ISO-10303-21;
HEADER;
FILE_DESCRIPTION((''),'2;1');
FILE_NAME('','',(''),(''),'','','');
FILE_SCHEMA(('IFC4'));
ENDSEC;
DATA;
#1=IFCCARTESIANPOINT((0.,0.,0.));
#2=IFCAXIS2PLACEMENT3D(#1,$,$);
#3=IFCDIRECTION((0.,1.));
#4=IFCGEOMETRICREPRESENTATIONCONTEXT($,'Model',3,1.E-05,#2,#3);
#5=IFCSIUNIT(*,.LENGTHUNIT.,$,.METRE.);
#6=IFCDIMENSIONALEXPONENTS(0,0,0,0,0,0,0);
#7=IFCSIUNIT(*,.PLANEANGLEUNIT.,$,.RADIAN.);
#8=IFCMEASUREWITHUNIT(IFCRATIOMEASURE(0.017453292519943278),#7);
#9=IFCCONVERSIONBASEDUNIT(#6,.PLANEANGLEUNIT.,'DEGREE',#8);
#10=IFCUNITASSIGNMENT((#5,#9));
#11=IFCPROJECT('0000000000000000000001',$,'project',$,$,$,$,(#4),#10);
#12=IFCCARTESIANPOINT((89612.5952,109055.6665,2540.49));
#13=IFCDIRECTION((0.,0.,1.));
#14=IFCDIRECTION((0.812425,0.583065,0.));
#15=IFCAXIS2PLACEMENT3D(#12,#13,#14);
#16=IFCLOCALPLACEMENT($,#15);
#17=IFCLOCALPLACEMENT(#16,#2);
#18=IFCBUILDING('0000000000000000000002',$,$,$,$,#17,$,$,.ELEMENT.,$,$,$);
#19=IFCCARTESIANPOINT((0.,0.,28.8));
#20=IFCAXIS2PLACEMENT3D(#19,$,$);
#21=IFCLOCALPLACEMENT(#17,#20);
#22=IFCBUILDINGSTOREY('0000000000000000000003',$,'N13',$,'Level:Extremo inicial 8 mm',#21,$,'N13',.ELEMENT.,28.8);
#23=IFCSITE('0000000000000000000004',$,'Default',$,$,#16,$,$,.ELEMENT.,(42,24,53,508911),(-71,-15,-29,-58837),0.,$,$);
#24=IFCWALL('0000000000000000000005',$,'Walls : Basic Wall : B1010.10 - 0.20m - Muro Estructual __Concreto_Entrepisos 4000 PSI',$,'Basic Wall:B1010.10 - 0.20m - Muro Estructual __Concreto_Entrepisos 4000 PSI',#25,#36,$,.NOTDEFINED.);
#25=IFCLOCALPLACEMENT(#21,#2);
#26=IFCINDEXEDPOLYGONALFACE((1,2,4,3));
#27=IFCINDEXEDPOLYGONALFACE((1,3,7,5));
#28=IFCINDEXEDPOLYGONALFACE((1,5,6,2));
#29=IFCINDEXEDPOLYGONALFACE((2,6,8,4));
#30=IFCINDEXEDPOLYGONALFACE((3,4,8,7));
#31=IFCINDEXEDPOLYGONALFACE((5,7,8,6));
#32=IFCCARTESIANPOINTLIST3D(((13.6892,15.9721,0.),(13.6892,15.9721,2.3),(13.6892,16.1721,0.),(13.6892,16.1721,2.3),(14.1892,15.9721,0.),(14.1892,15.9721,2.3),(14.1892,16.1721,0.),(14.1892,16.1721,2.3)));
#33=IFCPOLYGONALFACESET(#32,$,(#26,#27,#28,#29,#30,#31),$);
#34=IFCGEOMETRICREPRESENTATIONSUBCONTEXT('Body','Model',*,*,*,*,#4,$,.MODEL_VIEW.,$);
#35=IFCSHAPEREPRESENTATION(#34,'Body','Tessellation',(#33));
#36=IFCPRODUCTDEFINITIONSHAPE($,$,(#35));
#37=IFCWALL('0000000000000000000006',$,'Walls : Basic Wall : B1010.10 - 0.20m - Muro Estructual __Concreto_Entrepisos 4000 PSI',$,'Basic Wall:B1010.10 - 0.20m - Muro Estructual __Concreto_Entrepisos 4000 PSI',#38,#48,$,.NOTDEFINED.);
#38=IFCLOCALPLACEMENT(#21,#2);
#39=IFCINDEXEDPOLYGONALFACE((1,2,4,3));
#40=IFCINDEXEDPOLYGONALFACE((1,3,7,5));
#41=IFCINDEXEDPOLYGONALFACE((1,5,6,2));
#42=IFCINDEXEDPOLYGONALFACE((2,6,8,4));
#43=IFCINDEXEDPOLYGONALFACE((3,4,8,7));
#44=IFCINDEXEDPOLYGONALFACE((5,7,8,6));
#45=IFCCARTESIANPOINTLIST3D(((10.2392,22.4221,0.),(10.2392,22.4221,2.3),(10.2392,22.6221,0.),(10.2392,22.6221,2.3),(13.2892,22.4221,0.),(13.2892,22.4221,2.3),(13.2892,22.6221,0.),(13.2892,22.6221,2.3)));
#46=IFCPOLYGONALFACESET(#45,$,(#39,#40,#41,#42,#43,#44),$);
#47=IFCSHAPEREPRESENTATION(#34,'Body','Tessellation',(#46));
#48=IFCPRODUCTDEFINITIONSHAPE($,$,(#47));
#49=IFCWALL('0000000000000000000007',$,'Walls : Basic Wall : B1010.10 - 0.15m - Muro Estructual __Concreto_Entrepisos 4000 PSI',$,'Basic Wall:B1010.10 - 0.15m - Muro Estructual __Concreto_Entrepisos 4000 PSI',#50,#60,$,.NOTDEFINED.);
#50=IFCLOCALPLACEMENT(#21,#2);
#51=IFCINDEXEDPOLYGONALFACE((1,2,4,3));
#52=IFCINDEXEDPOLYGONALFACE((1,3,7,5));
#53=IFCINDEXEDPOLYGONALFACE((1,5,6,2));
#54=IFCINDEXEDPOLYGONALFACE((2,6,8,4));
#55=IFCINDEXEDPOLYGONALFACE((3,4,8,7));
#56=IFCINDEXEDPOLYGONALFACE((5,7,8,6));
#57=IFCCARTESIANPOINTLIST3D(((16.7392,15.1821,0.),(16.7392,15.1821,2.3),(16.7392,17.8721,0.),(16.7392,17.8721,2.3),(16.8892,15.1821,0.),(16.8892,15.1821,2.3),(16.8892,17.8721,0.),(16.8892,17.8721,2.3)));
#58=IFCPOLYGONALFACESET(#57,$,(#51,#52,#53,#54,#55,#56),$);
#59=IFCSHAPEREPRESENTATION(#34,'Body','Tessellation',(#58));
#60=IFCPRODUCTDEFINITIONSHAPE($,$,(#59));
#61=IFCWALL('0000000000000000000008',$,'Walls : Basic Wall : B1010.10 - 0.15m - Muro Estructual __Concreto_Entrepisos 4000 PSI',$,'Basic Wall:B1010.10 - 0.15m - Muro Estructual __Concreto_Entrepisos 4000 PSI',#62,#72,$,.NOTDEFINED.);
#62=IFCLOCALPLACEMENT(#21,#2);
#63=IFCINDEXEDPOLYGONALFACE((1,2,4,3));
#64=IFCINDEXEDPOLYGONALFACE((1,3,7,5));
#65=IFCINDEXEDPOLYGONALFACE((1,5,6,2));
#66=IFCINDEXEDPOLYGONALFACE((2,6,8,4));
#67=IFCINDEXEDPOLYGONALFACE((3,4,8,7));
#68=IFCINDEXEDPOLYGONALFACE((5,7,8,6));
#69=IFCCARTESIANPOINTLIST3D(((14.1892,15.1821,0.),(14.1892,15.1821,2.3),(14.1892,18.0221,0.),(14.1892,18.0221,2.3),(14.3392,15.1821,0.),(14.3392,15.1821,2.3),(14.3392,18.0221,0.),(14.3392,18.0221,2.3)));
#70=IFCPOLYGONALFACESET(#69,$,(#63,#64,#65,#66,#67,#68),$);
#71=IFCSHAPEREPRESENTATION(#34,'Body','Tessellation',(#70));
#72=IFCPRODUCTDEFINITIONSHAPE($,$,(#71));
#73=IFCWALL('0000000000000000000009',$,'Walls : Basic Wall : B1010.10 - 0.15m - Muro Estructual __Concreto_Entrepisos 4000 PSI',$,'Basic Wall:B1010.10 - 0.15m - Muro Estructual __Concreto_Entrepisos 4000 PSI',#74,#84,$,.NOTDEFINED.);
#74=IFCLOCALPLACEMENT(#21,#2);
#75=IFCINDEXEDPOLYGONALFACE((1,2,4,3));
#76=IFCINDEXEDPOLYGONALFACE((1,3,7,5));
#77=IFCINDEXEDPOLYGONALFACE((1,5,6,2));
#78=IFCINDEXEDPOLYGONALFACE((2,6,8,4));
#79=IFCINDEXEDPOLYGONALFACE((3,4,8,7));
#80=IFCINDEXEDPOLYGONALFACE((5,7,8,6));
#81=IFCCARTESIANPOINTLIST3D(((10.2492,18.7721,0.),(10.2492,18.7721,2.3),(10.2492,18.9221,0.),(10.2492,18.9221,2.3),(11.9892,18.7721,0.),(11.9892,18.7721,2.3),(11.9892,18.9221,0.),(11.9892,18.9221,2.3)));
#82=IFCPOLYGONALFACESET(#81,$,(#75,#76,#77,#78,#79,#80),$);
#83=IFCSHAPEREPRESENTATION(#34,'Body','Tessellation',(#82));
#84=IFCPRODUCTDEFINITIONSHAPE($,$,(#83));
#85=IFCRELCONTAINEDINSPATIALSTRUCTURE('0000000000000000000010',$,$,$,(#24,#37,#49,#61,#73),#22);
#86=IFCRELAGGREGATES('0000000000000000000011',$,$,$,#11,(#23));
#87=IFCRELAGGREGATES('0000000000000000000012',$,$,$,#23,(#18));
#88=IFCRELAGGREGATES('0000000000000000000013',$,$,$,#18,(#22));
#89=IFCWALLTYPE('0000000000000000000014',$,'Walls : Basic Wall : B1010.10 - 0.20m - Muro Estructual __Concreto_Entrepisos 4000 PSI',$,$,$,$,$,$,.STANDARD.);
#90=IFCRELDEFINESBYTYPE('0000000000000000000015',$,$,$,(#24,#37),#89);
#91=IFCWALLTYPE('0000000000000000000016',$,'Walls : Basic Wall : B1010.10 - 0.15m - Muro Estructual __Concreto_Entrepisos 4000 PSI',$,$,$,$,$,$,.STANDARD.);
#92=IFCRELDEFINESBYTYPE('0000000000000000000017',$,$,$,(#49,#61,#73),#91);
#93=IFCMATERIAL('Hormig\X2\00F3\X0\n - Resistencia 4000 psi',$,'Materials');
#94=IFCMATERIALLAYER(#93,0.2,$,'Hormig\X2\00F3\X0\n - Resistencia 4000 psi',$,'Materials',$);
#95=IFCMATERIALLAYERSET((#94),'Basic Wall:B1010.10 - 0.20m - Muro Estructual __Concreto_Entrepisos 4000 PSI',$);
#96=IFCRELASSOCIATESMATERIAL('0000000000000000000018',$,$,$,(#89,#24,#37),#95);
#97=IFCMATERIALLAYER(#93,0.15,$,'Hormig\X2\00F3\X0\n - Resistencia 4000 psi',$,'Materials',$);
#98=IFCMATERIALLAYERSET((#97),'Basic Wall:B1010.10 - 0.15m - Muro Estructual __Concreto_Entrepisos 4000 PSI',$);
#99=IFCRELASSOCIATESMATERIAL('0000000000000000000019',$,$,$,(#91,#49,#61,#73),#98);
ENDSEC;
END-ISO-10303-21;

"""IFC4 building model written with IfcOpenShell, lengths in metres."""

from ifc_helpers import new_model, entity, si_unit, converted_unit, direction, frame, frame_2d, origin, place, context, subcontext, project, spatial, rectangle, extrude, material, layer, layer_set, layer_usage, type_object, element, save


model = new_model("IFC4")

# Units and contexts
model_context = context("Model", 3, precision=1e-05, world=origin(), true_north=direction((0.0, 1.0)))
body_context = subcontext(model_context, "Body", "Model", "MODEL_VIEW")
ifc_project = project(units=[si_unit("LENGTHUNIT", "METRE"), converted_unit("PLANEANGLEUNIT", "DEGREE", entity("IfcRatioMeasure", 0.017453292519943278), si_unit("PLANEANGLEUNIT", "RADIAN"), dimensions=[0, 0, 0, 0, 0, 0, 0])], contexts=[model_context])

# Site, building, storey
site_placement = place(None, frame((89612.5952, 109055.6665, 2540.49), z_axis=(0.0, 0.0, 1.0), x_axis=(0.812425, 0.583065, 0.0)))
site = spatial("IfcSite", under=ifc_project, at=site_placement, Name="Default", CompositionType="ELEMENT", RefLatitude=(42, 24, 53, 508911), RefLongitude=(-71, -15, -29, -58837), RefElevation=0.0)
building_placement = place(site_placement, origin())
building = spatial("IfcBuilding", under=site, at=building_placement, CompositionType="ELEMENT")
storey_placement = place(building_placement, frame((0.0, 0.0, 28.8)))
storey = spatial("IfcBuildingStorey", under=building, at=storey_placement, Name="N13", ObjectType="Level:Extremo inicial 8 mm", LongName="N13", CompositionType="ELEMENT", Elevation=28.8)

# Walls
ifc_material_1 = material(Name="Hormigón - Resistencia 4000 psi", Category="Materials")
ifc_layer_1 = layer(ifc_material_1, 0.2, Name="Hormigón - Resistencia 4000 psi", Category="Materials")
ifc_layer_set_1 = layer_set([ifc_layer_1], Name="Basic Wall:B1010.10 - 0.20m - Muro Estructual __Concreto_Entrepisos 4000 PSI")
wall_type_1 = type_object("IfcWallType", Name="Walls : Basic Wall : B1010.10 - 0.20m - Muro Estructual __Concreto_Entrepisos 4000 PSI", PredefinedType="STANDARD", material=ifc_layer_set_1)
ifc_layer_usage_1 = layer_usage(ifc_layer_set_1, "AXIS2", "NEGATIVE", 0.1)
wall_1_placement = place(storey_placement, frame((13.6892, 16.0721, 0.0)))
element("IfcWall", 1, at=wall_1_placement, inside=storey, type_object=wall_type_1, material=ifc_layer_usage_1, Name="Walls : Basic Wall : B1010.10 - 0.20m - Muro Estructual __Concreto_Entrepisos 4000 PSI", ObjectType="Basic Wall:B1010.10 - 0.20m - Muro Estructual __Concreto_Entrepisos 4000 PSI", PredefinedType="NOTDEFINED", context=body_context, shape_type="SweptSolid", body=[
    extrude(rectangle(XDim=0.5, YDim=0.2, at=frame_2d((0.25, 0.0), x_axis=(-1.0, 0.0))), origin(), (0.0, 0.0, 1.0), 2.3),
])
ifc_layer_usage_2 = layer_usage(ifc_layer_set_1, "AXIS2", "POSITIVE", -0.1)
wall_2_placement = place(storey_placement, frame((10.2392, 22.5221, 0.0)))
element("IfcWall", 2, at=wall_2_placement, inside=storey, type_object=wall_type_1, material=ifc_layer_usage_2, Name="Walls : Basic Wall : B1010.10 - 0.20m - Muro Estructual __Concreto_Entrepisos 4000 PSI", ObjectType="Basic Wall:B1010.10 - 0.20m - Muro Estructual __Concreto_Entrepisos 4000 PSI", PredefinedType="NOTDEFINED", context=body_context, shape_type="SweptSolid", body=[
    extrude(rectangle(XDim=3.05, YDim=0.2, at=frame_2d((1.525, 0.0), x_axis=(-1.0, 0.0))), origin(), (0.0, 0.0, 1.0), 2.3),
])
ifc_layer_2 = layer(ifc_material_1, 0.15, Name="Hormigón - Resistencia 4000 psi", Category="Materials")
ifc_layer_set_2 = layer_set([ifc_layer_2], Name="Basic Wall:B1010.10 - 0.15m - Muro Estructual __Concreto_Entrepisos 4000 PSI")
ifc_layer_usage_3 = layer_usage(ifc_layer_set_2, "AXIS2", "NEGATIVE", 0.075)
wall_type_2 = type_object("IfcWallType", Name="Walls : Basic Wall : B1010.10 - 0.15m - Muro Estructual __Concreto_Entrepisos 4000 PSI", PredefinedType="STANDARD", material=ifc_layer_set_2)
wall_3_placement = place(storey_placement, frame((16.8142, 15.1821, 0.0), z_axis=(0.0, 0.0, 1.0), x_axis=(0.0, 1.0, 0.0)))
element("IfcWall", 3, at=wall_3_placement, inside=storey, type_object=wall_type_2, material=ifc_layer_usage_3, Name="Walls : Basic Wall : B1010.10 - 0.15m - Muro Estructual __Concreto_Entrepisos 4000 PSI", ObjectType="Basic Wall:B1010.10 - 0.15m - Muro Estructual __Concreto_Entrepisos 4000 PSI", PredefinedType="NOTDEFINED", context=body_context, shape_type="SweptSolid", body=[
    extrude(rectangle(XDim=2.69, YDim=0.15, at=frame_2d((1.345, 0.0), x_axis=(-1.0, 0.0))), origin(), (0.0, 0.0, 1.0), 2.3),
])
ifc_layer_usage_4 = layer_usage(ifc_layer_set_2, "AXIS2", "NEGATIVE", 0.075)
wall_4_placement = place(storey_placement, frame((14.2642, 15.1821, 0.0), z_axis=(0.0, 0.0, 1.0), x_axis=(0.0, 1.0, 0.0)))
element("IfcWall", 4, at=wall_4_placement, inside=storey, type_object=wall_type_2, material=ifc_layer_usage_4, Name="Walls : Basic Wall : B1010.10 - 0.15m - Muro Estructual __Concreto_Entrepisos 4000 PSI", ObjectType="Basic Wall:B1010.10 - 0.15m - Muro Estructual __Concreto_Entrepisos 4000 PSI", PredefinedType="NOTDEFINED", context=body_context, shape_type="SweptSolid", body=[
    extrude(rectangle(XDim=2.84, YDim=0.15, at=frame_2d((1.42, 0.0), x_axis=(-1.0, 0.0))), origin(), (0.0, 0.0, 1.0), 2.3),
])
ifc_layer_usage_5 = layer_usage(ifc_layer_set_2, "AXIS2", "NEGATIVE", 0.075)
wall_5_placement = place(storey_placement, frame((11.9892, 18.8471, 0.0), z_axis=(0.0, 0.0, 1.0), x_axis=(-1.0, 0.0, 0.0)))
element("IfcWall", 5, at=wall_5_placement, inside=storey, type_object=wall_type_2, material=ifc_layer_usage_5, Name="Walls : Basic Wall : B1010.10 - 0.15m - Muro Estructual __Concreto_Entrepisos 4000 PSI", ObjectType="Basic Wall:B1010.10 - 0.15m - Muro Estructual __Concreto_Entrepisos 4000 PSI", PredefinedType="NOTDEFINED", context=body_context, shape_type="SweptSolid", body=[
    extrude(rectangle(XDim=1.74, YDim=0.15, at=frame_2d((0.87, 0.0), x_axis=(-1.0, 0.0))), origin(), (0.0, 0.0, 1.0), 2.3),
])

save(model, "model.ifc")
